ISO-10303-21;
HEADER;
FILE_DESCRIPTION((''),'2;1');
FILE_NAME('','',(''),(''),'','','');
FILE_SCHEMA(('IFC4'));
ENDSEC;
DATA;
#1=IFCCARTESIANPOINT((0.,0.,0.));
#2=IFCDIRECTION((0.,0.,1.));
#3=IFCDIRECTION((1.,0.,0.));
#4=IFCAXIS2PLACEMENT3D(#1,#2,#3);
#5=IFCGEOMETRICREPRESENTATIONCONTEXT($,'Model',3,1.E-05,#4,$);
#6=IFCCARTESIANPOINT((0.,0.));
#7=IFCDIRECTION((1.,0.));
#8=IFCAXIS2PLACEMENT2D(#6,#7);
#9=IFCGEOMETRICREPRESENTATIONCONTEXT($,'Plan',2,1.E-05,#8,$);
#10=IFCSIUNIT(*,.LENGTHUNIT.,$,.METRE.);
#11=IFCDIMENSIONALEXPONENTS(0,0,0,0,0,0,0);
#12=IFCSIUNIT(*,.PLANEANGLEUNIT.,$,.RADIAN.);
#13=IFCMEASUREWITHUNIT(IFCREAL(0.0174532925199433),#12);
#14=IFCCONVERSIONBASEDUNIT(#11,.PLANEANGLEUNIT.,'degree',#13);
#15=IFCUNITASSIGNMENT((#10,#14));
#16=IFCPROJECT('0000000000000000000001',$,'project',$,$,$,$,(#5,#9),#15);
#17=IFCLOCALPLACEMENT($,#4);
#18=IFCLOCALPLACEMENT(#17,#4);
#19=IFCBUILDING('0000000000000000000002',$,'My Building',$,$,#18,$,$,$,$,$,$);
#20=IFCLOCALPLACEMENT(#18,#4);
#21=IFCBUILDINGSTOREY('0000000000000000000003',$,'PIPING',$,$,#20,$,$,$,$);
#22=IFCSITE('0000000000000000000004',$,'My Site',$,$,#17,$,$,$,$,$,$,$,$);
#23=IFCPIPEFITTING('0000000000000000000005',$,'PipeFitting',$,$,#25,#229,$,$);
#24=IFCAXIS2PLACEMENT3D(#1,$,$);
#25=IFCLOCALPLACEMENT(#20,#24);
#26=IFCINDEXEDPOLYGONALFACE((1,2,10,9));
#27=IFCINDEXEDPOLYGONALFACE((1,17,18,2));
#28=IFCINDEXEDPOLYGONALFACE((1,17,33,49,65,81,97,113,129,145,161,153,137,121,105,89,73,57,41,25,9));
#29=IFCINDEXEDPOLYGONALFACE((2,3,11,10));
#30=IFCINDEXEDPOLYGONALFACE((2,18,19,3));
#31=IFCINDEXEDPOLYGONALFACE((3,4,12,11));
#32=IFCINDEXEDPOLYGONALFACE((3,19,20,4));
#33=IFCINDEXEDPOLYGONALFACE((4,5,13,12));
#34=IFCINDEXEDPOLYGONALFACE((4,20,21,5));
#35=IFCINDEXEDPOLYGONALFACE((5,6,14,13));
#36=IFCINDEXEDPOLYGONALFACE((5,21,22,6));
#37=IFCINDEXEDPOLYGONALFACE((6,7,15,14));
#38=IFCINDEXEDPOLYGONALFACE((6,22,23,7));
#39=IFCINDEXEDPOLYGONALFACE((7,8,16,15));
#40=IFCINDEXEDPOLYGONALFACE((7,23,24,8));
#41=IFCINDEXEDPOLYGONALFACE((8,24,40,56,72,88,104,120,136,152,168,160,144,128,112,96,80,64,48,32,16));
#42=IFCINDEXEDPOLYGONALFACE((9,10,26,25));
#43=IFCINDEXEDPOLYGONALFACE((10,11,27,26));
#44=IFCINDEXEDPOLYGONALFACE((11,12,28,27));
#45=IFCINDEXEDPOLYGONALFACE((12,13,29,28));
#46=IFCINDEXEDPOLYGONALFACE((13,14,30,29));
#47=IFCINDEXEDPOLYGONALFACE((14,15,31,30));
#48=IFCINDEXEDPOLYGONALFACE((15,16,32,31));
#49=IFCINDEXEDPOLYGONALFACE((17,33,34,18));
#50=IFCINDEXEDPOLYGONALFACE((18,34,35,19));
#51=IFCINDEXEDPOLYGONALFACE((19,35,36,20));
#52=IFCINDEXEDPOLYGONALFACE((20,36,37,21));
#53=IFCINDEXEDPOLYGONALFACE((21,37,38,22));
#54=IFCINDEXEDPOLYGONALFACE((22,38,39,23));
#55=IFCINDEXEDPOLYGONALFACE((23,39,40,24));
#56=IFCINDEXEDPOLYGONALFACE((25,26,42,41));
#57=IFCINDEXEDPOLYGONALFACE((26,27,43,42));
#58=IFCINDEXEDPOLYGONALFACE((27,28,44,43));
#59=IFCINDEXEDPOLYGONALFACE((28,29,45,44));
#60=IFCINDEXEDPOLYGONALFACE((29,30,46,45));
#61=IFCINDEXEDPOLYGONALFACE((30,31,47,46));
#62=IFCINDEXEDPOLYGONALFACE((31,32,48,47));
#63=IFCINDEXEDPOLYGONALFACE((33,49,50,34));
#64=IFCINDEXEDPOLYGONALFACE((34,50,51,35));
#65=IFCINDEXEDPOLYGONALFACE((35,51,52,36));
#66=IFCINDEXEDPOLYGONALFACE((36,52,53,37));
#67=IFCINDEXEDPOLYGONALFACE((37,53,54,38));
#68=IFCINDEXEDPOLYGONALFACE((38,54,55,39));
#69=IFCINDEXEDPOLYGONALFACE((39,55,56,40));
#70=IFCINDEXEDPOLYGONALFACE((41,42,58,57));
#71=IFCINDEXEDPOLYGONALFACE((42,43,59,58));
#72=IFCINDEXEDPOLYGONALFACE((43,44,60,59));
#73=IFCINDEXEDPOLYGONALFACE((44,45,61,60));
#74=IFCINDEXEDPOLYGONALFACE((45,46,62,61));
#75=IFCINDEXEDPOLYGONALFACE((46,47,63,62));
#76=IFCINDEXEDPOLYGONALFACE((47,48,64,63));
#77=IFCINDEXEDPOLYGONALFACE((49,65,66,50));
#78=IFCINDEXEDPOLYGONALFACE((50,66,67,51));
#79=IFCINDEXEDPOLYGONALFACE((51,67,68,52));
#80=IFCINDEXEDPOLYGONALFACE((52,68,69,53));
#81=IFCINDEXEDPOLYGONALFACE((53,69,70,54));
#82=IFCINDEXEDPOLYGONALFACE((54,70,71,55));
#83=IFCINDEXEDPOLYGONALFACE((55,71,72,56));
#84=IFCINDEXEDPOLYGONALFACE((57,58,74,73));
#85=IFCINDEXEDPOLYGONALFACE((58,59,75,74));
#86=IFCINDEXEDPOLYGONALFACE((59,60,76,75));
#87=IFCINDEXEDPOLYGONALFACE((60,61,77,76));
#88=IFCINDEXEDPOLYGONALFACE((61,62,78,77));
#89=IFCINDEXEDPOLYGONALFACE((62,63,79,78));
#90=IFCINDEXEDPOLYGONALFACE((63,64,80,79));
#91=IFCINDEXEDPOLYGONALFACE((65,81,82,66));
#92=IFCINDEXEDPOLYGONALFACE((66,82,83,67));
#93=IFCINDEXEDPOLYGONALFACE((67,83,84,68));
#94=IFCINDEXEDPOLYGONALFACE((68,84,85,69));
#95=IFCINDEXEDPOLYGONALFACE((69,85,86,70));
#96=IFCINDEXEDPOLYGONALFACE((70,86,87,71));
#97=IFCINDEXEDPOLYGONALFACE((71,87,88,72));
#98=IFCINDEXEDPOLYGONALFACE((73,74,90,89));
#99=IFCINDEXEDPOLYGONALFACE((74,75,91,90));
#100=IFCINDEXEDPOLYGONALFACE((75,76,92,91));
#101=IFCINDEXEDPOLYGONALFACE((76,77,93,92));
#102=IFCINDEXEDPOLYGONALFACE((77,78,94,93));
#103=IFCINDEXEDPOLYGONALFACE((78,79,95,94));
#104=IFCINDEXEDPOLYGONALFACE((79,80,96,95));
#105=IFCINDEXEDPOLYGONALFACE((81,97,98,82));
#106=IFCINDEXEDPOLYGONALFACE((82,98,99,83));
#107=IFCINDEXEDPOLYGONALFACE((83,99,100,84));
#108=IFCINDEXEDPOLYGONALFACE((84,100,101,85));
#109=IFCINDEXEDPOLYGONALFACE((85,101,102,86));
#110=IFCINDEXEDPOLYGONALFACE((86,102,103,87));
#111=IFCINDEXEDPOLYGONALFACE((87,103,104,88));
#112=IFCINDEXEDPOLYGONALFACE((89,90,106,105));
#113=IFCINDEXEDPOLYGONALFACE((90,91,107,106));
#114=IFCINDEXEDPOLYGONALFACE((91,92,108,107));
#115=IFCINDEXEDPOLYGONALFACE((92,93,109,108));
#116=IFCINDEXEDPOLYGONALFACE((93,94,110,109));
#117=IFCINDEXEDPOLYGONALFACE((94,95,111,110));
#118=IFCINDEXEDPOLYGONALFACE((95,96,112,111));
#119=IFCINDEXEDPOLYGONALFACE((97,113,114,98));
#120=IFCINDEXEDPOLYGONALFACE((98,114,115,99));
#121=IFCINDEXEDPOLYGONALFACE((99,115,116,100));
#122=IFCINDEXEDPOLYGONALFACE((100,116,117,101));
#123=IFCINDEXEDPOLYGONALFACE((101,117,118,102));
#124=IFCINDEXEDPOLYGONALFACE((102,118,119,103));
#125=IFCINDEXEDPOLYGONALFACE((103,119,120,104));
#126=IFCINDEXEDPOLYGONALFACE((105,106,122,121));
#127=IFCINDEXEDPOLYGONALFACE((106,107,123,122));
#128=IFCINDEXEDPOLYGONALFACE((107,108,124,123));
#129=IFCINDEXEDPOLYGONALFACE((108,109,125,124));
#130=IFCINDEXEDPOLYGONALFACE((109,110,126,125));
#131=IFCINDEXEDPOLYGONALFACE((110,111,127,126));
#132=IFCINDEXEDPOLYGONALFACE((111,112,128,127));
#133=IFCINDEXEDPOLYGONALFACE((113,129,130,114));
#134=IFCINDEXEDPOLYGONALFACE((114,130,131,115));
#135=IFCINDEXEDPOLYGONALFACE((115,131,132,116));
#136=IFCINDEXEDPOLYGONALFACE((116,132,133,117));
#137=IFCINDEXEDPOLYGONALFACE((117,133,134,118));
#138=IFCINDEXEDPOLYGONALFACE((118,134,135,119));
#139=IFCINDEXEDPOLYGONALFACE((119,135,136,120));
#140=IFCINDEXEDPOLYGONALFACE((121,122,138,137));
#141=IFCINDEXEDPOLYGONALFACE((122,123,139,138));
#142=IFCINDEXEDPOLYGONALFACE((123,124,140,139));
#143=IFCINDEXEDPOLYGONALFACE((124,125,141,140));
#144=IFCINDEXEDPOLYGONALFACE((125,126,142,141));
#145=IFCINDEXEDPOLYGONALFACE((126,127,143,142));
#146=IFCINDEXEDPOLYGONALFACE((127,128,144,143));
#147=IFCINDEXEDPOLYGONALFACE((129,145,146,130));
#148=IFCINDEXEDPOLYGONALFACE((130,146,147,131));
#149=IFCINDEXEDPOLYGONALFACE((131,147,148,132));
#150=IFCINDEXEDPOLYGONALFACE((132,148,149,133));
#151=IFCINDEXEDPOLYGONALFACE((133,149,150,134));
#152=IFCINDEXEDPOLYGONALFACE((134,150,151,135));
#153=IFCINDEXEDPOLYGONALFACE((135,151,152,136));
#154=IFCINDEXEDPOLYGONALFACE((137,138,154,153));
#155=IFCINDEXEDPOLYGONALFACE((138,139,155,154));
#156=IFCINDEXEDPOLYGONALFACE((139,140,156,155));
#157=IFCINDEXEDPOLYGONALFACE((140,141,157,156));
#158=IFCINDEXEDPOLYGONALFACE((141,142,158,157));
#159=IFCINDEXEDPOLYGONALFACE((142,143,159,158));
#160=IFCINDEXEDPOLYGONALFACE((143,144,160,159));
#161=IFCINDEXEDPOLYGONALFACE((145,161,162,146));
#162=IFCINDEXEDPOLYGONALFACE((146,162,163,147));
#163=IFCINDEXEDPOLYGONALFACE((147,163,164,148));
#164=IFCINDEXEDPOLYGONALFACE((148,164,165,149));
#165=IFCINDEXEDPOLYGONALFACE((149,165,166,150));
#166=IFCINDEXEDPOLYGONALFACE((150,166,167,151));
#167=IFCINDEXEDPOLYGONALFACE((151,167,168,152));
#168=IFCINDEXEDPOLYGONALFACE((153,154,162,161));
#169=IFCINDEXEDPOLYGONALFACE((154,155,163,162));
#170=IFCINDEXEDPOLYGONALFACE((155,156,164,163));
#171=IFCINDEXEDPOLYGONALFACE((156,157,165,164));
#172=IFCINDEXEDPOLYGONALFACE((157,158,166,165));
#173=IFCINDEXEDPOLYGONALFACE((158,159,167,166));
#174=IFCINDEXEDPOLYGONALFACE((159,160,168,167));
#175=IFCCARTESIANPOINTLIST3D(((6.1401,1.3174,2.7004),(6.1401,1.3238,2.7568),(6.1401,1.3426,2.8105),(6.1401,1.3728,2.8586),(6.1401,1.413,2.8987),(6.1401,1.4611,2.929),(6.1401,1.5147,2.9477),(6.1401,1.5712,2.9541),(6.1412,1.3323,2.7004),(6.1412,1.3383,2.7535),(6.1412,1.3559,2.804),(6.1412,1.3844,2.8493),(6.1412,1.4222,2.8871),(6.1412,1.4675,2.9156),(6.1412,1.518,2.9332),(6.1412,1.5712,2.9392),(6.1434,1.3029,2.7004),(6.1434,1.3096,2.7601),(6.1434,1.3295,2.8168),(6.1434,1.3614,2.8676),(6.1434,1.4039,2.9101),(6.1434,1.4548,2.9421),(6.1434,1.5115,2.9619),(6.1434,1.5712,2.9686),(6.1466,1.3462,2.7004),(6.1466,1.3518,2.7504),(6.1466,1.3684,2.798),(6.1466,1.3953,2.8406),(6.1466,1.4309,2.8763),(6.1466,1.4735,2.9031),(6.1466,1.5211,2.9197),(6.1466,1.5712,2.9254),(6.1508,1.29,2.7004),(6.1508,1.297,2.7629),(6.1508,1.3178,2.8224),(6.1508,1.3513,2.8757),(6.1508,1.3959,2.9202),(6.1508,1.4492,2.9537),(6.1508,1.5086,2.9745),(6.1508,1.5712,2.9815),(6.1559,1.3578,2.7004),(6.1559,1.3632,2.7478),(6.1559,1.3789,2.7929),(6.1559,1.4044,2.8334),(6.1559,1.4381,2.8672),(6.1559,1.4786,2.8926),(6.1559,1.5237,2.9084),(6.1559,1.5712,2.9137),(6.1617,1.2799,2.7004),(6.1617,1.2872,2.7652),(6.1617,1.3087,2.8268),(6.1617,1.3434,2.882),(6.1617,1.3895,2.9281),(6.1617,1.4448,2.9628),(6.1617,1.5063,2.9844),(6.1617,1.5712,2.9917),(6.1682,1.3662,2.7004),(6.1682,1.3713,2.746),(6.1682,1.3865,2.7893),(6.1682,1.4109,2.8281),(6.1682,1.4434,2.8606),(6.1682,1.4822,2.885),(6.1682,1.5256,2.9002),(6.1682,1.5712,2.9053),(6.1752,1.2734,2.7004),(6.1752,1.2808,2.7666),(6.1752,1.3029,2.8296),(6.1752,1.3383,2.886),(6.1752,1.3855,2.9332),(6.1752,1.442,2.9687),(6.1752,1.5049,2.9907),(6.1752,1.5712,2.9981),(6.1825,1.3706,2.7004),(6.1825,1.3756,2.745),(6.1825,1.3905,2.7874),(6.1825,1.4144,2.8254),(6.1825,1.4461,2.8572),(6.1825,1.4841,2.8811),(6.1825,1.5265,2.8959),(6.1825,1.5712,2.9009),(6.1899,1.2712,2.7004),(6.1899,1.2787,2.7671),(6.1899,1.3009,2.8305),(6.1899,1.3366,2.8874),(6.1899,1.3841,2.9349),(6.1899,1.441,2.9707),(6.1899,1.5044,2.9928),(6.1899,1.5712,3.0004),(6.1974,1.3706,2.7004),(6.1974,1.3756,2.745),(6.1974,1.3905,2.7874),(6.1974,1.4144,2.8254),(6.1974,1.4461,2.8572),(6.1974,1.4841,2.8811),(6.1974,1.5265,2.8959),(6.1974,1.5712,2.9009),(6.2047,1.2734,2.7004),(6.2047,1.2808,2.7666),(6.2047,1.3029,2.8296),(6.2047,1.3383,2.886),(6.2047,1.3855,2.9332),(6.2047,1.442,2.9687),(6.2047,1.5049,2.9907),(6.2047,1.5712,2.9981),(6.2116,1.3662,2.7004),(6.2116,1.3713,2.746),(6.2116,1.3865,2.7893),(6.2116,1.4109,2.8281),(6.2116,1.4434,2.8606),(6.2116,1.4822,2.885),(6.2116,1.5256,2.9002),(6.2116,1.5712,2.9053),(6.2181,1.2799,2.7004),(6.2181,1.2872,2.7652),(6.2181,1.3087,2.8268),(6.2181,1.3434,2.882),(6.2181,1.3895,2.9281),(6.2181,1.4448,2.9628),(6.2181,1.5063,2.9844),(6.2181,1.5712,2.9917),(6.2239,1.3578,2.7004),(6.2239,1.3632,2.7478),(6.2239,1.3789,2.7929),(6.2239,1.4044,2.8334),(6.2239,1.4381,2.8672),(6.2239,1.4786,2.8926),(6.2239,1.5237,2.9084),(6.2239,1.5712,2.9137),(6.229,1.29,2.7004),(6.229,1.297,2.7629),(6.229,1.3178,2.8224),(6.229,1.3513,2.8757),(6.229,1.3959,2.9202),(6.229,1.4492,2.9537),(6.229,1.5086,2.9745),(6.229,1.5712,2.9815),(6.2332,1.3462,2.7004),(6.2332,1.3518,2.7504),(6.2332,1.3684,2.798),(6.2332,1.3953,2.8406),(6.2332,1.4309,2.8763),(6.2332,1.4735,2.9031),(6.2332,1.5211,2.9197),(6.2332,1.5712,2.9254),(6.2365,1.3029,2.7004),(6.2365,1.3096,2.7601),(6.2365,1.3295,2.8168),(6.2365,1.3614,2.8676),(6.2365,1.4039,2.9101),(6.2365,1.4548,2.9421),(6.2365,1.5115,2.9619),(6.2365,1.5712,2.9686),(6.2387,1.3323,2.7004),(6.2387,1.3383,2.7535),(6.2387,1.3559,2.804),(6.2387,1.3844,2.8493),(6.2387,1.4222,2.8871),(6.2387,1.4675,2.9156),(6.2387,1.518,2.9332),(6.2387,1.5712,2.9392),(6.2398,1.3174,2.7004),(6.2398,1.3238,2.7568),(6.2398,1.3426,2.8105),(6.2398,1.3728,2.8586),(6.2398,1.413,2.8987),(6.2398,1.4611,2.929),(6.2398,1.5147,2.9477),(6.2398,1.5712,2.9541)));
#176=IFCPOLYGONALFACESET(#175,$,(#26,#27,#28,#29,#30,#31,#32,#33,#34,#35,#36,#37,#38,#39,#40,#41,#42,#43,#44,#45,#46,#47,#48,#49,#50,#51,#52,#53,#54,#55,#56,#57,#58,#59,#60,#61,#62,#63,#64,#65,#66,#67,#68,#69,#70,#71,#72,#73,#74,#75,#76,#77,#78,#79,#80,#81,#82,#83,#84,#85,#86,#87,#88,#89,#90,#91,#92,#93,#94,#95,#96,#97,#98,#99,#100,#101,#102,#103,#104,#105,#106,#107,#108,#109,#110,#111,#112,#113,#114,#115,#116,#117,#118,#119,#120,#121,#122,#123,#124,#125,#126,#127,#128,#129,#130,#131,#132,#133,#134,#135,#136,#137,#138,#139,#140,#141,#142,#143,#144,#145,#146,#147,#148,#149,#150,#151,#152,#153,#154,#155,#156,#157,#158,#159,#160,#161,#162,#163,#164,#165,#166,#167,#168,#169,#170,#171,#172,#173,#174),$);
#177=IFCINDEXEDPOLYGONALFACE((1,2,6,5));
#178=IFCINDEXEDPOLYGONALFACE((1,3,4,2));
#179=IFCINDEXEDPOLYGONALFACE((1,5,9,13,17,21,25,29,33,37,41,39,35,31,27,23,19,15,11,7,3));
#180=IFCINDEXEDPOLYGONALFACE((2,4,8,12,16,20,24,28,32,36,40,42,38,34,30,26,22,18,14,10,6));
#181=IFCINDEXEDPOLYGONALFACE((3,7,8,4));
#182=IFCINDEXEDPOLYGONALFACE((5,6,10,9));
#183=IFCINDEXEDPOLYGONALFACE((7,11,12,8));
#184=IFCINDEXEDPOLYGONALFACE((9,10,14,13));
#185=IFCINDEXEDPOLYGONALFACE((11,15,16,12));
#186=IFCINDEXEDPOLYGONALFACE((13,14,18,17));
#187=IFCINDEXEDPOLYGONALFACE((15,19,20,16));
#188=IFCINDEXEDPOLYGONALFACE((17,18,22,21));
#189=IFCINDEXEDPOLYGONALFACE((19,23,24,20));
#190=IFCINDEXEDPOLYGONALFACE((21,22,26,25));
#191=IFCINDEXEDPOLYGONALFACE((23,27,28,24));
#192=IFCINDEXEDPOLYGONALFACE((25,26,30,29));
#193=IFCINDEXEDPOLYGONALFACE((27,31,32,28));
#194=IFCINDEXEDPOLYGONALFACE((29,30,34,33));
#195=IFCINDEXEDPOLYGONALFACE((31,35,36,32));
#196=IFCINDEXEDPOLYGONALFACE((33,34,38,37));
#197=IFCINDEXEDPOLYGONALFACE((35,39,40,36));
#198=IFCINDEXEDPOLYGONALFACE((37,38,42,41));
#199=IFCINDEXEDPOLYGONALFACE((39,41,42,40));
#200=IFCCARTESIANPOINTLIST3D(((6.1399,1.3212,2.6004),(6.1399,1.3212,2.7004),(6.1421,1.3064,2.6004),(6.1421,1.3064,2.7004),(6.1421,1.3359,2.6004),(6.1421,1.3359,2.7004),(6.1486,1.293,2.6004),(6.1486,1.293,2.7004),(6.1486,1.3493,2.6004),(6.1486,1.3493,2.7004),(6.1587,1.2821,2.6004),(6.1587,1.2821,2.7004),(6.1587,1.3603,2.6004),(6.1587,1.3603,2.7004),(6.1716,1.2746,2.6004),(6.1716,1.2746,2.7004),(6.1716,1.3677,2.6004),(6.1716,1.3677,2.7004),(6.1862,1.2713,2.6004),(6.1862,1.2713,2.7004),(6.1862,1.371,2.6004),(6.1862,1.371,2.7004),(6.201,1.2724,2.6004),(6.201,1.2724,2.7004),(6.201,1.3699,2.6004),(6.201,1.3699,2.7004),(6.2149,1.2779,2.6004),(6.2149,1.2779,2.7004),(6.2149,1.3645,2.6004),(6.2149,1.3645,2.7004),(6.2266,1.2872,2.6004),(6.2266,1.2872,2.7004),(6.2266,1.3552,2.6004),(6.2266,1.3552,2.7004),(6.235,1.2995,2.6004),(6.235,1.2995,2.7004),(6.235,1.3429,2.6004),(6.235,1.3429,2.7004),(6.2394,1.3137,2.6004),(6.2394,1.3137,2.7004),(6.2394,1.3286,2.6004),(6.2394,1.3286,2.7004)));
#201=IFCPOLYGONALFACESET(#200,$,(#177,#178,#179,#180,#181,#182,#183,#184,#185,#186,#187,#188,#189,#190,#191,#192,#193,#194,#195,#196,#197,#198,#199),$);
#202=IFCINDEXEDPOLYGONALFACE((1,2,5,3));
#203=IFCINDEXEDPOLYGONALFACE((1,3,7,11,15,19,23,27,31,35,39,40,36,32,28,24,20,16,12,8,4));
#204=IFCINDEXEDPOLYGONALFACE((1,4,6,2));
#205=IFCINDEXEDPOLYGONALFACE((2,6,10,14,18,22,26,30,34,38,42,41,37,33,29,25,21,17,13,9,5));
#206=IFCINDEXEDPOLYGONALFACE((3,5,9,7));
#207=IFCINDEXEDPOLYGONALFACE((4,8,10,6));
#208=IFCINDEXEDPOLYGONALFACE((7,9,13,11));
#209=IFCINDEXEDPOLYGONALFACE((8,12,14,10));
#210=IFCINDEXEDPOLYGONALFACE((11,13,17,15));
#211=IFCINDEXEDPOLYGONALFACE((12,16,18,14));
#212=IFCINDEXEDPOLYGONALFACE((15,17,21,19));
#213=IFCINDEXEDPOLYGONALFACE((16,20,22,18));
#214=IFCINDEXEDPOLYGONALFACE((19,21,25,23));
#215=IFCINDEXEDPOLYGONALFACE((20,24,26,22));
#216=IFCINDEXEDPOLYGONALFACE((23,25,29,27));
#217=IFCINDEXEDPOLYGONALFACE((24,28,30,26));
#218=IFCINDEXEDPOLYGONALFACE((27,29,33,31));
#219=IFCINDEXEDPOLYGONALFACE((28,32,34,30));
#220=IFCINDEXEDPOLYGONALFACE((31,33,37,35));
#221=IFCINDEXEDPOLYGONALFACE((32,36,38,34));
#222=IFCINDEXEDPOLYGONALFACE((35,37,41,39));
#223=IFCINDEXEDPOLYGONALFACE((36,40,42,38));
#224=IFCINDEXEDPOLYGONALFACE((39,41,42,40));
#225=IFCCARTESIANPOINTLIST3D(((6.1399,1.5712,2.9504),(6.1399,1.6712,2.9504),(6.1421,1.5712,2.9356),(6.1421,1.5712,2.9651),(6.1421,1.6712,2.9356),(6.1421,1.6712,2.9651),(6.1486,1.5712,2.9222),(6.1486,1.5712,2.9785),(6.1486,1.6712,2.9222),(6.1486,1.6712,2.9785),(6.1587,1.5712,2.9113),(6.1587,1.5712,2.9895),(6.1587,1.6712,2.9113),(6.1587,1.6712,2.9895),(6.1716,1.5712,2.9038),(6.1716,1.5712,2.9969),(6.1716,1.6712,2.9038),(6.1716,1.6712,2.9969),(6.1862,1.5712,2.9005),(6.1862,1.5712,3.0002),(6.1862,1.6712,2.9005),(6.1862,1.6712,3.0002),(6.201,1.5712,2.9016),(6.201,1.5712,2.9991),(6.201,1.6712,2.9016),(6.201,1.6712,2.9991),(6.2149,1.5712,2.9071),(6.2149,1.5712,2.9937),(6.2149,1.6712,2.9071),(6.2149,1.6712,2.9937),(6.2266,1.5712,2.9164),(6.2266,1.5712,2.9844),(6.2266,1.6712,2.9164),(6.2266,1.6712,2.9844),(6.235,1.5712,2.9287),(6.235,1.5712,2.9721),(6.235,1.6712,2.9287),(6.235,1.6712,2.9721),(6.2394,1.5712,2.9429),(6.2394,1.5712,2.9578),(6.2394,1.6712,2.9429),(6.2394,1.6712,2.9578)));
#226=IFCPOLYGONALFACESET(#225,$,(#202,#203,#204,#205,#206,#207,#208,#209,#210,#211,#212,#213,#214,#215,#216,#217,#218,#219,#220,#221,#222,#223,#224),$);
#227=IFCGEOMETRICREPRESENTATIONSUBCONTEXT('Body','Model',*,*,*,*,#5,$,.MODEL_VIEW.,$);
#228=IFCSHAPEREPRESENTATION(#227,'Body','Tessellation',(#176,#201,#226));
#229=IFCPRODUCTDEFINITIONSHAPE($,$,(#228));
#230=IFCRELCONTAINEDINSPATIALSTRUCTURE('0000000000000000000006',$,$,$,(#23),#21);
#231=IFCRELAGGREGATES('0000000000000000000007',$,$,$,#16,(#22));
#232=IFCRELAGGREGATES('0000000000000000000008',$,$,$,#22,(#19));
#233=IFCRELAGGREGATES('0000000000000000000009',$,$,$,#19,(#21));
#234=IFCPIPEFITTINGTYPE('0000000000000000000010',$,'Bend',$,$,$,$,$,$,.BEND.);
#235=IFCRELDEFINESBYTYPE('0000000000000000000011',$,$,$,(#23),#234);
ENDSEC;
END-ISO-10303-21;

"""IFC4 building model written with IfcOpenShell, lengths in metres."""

from ifc_helpers import new_model, entity, si_unit, converted_unit, frame, origin_with_axes, origin_2d_with_axis, place, context, subcontext, project, spatial, circle, extrude, source, transform, mapped, type_object, type_shapes, element, save


model = new_model("IFC4")

# Units and contexts
model_context = context("Model", 3, precision=1e-05, world=origin_with_axes())
plan_context = context("Plan", 2, precision=1e-05, world=origin_2d_with_axis())
body_context = subcontext(model_context, "Body", "Model", "MODEL_VIEW")
ifc_project = project(units=[si_unit("LENGTHUNIT", "METRE"), converted_unit("PLANEANGLEUNIT", "degree", entity("IfcReal", 0.0174532925199433), si_unit("PLANEANGLEUNIT", "RADIAN"), dimensions=[0, 0, 0, 0, 0, 0, 0])], contexts=[model_context, plan_context])

# Site, building, storey
site_placement = place(None, origin_with_axes())
site = spatial("IfcSite", under=ifc_project, at=site_placement, Name="My Site")
building_placement = place(site_placement, origin_with_axes())
building = spatial("IfcBuilding", under=site, at=building_placement, Name="My Building")
storey_placement = place(building_placement, origin_with_axes())
storey = spatial("IfcBuildingStorey", under=building, at=storey_placement, Name="PIPING")

# Pipe fitting
pipe_fitting_type_1 = type_object("IfcPipeFittingType", Name="Bend", PredefinedType="BEND")
shared_shape = source(origin_with_axes(), body_context, "Body", "SolidModel", [
    entity("IfcSweptDiskSolid", entity("IfcIndexedPolyCurve", entity("IfcCartesianPointList3D", [[0.0, 0.0, -0.1], [0.0, 0.0732, -0.2768], [0.0, 0.25, -0.35]]), [entity("IfcArcIndex", [1, 2, 3])]), 0.05),
    extrude(circle(Radius=0.05), origin_with_axes(), (0.0, 0.0, -1.0), 0.1),
    extrude(circle(Radius=0.05), frame((0.0, 0.25, -0.35), z_axis=(0.0, 1.0, 0.0), x_axis=(1.0, 0.0, 0.0)), (0.0, 0.0, 1.0), 0.1),
])
type_shapes(pipe_fitting_type_1, [shared_shape])
for number, where, z_axis, x_axis, name in (
    (1, (6.1899, 1.3212, 2.6004), (0.0, 0.0, -1.0), (-1.0, 0.0, 0.0), "PipeFitting"),
):
    element("IfcPipeFitting", number, at=place(storey_placement, frame(where, z_axis=z_axis, x_axis=x_axis)), inside=storey, type_object=pipe_fitting_type_1, Name=name, context=body_context, shape_type="MappedRepresentation", body=[
        mapped(shared_shape, transform((0.0, 0.0, 0.0), x_axis=(1.0, 0.0, 0.0), y_axis=(0.0, 1.0, 0.0), z_axis=(0.0, 0.0, 1.0), scale=1.0)),
    ])

save(model, "model.ifc")
